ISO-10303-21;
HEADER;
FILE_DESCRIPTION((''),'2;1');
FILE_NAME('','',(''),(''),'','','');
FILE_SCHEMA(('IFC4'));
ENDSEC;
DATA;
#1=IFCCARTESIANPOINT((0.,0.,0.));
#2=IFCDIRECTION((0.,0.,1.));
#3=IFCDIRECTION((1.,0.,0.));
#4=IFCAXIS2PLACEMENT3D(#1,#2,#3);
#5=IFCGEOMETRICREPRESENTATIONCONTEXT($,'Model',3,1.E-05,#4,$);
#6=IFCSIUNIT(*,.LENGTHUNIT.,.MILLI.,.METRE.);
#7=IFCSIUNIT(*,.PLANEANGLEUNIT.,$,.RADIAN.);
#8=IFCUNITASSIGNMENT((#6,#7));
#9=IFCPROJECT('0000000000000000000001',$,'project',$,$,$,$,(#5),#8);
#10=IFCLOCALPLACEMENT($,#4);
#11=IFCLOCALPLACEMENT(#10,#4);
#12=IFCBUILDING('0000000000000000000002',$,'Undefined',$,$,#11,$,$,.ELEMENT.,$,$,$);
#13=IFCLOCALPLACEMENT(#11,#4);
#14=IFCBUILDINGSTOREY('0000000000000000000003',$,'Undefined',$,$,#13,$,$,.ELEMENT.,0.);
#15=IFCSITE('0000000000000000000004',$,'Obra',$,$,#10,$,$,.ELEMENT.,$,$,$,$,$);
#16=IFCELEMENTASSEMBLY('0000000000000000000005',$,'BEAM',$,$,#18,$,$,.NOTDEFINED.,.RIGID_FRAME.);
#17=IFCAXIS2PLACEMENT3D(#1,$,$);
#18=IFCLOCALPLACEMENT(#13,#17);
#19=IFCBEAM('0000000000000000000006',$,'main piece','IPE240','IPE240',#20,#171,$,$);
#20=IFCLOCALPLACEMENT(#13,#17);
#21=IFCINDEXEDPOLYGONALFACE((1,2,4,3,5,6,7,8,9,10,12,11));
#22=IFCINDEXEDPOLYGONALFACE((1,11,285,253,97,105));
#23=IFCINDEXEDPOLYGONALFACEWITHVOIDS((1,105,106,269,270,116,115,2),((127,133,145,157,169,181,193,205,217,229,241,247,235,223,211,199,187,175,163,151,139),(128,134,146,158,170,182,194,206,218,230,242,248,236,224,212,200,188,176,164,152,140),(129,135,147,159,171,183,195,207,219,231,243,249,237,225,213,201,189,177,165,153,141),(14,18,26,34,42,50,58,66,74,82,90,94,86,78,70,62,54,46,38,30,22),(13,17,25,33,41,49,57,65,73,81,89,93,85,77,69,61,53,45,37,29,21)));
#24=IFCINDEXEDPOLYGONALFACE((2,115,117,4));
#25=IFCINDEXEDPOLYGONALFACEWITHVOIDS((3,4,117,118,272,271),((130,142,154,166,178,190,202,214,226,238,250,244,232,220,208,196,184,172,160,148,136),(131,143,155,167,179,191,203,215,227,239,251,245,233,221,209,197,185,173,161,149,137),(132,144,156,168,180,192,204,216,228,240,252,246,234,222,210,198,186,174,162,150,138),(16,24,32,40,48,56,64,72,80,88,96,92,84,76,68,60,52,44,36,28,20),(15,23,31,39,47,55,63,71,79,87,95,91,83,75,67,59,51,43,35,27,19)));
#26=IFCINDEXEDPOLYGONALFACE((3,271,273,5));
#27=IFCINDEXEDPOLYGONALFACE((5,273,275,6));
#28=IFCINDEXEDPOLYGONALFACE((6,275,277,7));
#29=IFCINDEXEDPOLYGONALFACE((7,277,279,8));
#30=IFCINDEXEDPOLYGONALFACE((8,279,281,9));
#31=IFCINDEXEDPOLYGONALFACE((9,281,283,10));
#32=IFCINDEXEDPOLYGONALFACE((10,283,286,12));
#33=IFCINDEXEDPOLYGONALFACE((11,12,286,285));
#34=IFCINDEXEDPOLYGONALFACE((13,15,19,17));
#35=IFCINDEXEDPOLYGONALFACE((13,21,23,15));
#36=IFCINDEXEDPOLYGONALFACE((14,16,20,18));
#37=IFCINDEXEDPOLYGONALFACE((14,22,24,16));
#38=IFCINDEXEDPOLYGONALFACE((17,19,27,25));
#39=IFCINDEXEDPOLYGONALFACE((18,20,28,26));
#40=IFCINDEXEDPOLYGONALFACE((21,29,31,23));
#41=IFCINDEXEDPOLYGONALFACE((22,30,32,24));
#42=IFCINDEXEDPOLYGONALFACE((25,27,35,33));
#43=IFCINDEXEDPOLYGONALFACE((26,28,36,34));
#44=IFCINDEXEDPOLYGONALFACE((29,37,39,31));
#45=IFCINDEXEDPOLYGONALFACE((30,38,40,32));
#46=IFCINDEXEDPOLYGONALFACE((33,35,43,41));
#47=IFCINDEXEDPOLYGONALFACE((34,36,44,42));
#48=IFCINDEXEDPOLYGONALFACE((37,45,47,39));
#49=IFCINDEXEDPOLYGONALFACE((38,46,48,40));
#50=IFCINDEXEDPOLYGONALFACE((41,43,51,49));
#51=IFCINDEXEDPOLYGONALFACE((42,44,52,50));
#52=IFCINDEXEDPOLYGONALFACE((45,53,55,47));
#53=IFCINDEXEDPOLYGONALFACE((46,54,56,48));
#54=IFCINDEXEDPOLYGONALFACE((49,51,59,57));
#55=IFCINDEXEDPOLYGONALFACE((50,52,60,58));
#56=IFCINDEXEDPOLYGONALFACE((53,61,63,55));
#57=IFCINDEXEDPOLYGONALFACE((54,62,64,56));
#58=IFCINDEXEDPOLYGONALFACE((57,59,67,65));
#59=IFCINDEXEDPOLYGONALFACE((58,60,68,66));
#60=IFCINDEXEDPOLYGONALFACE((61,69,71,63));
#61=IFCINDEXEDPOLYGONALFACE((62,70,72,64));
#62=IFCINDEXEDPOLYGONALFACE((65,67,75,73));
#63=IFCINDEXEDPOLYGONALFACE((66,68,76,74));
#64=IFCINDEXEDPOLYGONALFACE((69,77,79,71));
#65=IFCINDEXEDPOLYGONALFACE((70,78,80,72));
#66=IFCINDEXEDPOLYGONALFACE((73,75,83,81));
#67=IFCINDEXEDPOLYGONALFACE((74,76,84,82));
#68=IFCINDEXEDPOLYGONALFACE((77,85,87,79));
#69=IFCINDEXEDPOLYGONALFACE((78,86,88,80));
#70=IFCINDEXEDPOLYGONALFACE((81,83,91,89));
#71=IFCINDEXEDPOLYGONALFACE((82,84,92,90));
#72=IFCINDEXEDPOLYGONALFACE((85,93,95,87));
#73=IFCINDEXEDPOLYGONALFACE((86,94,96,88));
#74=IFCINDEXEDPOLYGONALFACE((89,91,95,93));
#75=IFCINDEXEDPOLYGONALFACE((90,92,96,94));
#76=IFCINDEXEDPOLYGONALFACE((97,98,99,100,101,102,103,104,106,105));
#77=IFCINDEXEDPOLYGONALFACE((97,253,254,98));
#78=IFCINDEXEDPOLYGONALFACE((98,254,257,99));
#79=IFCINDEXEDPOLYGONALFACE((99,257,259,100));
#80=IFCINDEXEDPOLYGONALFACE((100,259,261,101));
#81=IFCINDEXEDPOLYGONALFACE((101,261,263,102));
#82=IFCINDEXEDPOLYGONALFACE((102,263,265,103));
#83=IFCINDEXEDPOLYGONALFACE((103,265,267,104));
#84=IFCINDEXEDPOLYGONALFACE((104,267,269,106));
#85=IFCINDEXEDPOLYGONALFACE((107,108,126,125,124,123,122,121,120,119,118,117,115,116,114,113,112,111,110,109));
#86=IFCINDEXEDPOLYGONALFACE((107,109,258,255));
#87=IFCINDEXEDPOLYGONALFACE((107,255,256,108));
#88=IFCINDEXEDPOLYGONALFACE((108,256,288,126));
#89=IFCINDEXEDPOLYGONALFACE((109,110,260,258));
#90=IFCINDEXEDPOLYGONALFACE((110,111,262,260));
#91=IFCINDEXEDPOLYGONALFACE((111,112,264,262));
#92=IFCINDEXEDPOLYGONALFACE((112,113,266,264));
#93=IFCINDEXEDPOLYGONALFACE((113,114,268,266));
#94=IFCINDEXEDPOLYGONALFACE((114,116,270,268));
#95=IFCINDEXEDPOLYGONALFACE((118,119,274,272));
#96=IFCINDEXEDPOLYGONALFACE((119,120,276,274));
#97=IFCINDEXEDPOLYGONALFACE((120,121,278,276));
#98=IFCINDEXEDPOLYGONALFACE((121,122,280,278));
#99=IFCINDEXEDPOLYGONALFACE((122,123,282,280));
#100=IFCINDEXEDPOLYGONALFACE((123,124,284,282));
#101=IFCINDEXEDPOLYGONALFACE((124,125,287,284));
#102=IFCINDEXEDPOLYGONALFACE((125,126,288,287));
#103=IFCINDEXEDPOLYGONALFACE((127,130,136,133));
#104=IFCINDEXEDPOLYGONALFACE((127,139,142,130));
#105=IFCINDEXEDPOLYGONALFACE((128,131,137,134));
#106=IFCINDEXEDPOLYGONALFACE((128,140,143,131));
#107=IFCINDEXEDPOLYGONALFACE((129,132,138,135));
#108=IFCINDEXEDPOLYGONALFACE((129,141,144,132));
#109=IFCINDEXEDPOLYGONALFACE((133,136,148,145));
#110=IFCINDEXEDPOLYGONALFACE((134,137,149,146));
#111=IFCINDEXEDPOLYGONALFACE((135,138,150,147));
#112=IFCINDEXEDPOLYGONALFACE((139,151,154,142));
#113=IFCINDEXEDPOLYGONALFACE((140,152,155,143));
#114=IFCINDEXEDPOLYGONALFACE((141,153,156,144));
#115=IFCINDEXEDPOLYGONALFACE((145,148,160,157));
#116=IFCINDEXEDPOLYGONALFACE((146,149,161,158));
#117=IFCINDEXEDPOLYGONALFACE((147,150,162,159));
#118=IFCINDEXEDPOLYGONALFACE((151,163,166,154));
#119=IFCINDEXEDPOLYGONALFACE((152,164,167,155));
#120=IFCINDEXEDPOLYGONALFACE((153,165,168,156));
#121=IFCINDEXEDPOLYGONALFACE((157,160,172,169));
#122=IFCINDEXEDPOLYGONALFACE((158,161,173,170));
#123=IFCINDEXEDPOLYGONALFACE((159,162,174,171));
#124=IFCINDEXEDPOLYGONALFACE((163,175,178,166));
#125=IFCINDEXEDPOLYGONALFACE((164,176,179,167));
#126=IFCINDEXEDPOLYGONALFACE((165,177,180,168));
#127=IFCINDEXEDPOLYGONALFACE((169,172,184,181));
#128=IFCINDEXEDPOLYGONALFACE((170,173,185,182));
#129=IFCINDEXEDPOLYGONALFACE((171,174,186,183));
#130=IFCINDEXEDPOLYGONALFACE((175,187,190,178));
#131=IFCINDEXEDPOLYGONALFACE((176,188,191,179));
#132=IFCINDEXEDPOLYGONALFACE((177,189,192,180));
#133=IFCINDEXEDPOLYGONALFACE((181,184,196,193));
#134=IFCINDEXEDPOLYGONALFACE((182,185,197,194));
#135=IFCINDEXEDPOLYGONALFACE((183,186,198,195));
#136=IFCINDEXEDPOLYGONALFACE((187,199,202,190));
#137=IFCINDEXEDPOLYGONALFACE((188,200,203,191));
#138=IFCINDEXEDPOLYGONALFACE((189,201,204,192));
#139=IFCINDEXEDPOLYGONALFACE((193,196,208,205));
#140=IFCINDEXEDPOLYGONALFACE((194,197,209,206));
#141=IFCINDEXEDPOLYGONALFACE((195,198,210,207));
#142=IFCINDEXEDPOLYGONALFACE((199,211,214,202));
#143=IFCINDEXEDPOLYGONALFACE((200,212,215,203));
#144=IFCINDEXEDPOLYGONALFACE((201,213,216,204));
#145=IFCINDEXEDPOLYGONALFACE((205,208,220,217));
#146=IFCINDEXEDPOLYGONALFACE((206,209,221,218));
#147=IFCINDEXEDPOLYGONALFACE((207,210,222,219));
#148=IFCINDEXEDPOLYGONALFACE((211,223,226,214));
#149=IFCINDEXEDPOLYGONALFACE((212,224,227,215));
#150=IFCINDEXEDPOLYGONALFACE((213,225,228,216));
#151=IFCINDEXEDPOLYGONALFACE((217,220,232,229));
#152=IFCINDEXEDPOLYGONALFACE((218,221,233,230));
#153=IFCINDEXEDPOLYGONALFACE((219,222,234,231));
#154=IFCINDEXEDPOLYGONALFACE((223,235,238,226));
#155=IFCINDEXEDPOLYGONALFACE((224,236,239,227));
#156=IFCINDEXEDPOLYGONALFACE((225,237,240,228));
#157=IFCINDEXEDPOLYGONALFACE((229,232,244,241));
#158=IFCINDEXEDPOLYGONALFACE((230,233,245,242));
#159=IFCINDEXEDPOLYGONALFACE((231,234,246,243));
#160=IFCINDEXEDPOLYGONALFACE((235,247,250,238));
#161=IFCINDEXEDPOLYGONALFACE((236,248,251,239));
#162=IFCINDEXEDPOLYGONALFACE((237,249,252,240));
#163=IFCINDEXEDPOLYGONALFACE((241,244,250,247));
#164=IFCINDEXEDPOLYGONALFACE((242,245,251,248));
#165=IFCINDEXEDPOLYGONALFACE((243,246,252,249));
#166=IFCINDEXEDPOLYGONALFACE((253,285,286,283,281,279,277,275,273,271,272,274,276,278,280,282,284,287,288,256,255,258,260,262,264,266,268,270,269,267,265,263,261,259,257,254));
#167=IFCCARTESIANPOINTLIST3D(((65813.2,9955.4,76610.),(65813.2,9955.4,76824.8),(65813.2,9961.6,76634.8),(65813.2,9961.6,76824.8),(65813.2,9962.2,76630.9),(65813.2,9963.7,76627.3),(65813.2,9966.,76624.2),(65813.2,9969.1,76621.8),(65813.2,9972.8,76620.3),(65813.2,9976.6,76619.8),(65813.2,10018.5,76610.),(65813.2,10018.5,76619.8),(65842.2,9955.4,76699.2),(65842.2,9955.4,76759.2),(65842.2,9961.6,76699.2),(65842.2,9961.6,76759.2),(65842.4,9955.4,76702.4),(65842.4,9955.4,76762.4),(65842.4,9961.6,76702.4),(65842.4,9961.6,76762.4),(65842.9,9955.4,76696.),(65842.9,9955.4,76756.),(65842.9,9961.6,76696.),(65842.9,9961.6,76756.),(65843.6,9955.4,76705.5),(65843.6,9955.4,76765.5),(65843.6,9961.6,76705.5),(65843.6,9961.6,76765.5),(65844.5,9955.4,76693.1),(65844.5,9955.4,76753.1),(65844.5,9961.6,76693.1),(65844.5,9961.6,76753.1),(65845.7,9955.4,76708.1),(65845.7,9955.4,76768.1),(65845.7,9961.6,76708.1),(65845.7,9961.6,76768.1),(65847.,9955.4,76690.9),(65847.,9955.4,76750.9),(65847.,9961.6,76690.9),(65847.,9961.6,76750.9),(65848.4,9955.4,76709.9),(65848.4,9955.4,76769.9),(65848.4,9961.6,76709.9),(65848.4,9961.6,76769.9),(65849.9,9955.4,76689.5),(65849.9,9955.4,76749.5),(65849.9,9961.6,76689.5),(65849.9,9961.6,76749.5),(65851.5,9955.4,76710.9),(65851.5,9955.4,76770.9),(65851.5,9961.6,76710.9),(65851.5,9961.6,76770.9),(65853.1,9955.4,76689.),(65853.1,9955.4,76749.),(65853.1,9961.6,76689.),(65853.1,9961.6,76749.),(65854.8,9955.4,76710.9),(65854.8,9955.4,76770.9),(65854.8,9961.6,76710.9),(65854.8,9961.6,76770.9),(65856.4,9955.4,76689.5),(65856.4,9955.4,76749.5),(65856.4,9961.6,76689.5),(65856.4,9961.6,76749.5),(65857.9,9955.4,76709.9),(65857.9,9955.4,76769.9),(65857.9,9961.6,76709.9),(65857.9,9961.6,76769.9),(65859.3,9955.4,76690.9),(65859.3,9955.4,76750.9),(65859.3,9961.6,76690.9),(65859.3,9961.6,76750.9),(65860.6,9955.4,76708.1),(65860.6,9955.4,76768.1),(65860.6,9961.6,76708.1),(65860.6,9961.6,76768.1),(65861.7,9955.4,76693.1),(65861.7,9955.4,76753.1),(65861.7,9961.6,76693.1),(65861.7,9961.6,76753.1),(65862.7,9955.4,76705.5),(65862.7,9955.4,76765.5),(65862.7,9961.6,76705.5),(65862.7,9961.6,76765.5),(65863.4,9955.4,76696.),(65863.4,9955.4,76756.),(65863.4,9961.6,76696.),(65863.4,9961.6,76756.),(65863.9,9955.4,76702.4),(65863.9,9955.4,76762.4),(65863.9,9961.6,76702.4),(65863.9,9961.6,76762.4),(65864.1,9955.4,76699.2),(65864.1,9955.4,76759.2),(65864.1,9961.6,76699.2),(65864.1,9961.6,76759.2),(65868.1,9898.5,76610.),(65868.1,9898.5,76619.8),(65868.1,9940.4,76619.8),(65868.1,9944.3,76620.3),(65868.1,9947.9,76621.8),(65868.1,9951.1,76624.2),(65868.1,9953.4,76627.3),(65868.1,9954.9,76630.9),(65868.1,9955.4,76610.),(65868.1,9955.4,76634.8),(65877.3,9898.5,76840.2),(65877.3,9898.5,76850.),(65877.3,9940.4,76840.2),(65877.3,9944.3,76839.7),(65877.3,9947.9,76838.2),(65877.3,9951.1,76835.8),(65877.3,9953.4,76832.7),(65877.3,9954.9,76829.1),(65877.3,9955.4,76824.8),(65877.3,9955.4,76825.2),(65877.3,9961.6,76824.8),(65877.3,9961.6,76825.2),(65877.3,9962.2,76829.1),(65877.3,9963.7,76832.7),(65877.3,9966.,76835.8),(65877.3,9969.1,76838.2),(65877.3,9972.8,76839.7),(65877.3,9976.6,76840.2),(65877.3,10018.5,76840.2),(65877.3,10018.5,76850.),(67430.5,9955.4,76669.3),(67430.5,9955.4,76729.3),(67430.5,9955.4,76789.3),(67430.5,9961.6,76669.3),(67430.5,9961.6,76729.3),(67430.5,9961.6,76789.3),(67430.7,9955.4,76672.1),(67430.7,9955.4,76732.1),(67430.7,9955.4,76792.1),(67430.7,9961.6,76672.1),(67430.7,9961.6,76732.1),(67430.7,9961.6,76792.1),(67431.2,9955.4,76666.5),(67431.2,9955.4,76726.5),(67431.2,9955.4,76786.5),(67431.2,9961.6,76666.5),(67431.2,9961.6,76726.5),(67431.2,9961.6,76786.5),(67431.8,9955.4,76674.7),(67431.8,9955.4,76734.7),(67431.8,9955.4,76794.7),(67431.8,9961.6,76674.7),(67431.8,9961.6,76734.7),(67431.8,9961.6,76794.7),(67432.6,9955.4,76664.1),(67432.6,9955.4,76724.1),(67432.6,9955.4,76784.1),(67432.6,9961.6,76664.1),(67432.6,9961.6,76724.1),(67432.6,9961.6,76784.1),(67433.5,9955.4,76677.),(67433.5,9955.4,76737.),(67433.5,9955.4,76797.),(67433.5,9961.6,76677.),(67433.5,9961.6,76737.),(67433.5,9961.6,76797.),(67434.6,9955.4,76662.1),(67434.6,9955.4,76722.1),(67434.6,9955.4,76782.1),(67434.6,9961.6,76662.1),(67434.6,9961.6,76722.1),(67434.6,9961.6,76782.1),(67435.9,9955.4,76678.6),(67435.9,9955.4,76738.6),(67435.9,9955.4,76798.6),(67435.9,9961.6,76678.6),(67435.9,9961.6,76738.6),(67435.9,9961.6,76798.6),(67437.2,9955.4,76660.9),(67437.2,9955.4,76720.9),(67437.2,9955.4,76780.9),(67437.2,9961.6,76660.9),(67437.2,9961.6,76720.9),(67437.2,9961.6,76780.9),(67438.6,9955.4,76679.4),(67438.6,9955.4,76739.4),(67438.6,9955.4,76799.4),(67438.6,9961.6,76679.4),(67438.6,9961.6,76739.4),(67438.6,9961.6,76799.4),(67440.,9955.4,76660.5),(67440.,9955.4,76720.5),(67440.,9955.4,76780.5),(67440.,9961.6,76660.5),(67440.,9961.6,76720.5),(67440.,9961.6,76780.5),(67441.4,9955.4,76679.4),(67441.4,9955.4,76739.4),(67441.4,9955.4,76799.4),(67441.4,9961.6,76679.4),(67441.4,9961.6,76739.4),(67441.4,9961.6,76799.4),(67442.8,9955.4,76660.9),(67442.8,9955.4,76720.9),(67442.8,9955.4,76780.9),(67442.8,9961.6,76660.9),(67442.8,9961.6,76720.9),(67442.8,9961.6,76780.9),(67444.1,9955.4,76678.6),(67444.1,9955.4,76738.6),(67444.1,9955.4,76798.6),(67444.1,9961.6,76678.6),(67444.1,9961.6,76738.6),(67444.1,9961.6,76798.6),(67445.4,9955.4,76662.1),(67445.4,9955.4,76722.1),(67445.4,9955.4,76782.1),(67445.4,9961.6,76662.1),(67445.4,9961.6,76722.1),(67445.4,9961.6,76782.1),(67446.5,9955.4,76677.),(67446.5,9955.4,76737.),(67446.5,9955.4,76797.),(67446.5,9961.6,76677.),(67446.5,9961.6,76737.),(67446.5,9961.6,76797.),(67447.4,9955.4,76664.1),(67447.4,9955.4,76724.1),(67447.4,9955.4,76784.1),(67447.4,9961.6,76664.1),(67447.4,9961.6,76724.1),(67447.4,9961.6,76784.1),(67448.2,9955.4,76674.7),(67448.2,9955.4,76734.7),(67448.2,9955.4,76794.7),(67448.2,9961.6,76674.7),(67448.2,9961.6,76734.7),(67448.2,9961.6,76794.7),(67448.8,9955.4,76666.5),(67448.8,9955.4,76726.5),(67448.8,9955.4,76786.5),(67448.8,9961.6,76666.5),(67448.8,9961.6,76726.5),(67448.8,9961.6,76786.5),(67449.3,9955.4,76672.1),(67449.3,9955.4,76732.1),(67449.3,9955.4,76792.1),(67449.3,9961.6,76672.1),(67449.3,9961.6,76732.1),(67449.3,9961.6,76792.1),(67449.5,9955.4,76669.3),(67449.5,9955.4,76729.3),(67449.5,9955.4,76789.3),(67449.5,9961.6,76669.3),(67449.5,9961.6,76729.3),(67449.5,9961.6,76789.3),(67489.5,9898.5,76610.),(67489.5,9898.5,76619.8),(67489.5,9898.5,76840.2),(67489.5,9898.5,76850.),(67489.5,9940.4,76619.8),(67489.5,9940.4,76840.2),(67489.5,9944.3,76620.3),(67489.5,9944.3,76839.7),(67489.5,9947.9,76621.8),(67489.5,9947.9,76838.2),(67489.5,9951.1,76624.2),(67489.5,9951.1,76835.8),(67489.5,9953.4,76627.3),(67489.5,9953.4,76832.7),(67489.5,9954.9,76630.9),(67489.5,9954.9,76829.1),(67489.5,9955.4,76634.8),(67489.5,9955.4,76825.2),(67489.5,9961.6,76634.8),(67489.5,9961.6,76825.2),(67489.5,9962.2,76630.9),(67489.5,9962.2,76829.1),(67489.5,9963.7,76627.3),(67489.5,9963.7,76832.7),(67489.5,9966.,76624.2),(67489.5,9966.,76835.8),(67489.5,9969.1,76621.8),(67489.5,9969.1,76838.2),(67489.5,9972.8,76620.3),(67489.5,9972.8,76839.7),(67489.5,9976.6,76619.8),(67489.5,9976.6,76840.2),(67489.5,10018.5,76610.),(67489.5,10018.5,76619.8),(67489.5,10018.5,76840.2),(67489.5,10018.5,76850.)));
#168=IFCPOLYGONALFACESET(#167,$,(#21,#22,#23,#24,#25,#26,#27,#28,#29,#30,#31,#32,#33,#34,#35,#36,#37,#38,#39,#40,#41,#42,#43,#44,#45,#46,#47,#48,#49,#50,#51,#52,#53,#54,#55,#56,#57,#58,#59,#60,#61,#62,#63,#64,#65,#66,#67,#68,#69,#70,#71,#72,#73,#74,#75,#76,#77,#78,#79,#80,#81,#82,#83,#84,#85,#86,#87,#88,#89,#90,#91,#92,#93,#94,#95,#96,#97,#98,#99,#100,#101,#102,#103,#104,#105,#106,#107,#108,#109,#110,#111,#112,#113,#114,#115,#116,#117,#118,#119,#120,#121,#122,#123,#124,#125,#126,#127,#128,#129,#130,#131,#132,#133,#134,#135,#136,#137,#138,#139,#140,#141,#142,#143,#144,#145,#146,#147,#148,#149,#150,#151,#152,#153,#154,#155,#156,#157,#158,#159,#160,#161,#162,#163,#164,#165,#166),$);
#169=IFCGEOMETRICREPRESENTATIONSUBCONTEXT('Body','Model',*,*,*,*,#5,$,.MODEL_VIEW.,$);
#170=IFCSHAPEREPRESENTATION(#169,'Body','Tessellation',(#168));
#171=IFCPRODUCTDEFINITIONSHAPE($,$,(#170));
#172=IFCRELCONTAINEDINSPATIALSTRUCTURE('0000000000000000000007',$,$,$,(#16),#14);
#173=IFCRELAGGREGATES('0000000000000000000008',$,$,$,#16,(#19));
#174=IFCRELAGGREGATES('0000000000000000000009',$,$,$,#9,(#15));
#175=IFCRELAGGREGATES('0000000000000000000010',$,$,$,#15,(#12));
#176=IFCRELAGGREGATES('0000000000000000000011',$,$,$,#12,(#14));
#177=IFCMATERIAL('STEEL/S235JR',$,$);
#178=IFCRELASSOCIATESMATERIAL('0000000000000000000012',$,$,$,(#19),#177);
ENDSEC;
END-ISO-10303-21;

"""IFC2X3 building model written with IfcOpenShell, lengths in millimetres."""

from ifc_helpers import new_model, si_unit, frame, origin_with_axes, origin_2d_with_axis, place, context, subcontext, project, spatial, rectangle, circle, i_section, extrude, clip, halfspace, source, transform, mapped, material, element, aggregate, save


model = new_model("IFC2X3")

# Units and contexts
model_context = context("Model", 3, precision=1e-05, world=origin_with_axes())
body_context = subcontext(model_context, "Body", "Model", "MODEL_VIEW")
ifc_project = project(units=[si_unit("LENGTHUNIT", "METRE", prefix="MILLI"), si_unit("PLANEANGLEUNIT", "RADIAN")], contexts=[model_context])

# Site, building, storey
site_placement = place(None, origin_with_axes())
site = spatial("IfcSite", under=ifc_project, at=site_placement, Name="Obra", CompositionType="ELEMENT")
building_placement = place(site_placement, origin_with_axes())
building = spatial("IfcBuilding", under=site, at=building_placement, Name="Undefined", CompositionType="ELEMENT")
storey_placement = place(building_placement, origin_with_axes())
storey = spatial("IfcBuildingStorey", under=building, at=storey_placement, Name="Undefined", CompositionType="ELEMENT", Elevation=0.0)

# Element assembly, beam, openings
ifc_material_1 = material(Name="STEEL/S235JR")
shared_shape_1 = source(origin_with_axes(), body_context, "Body", "SweptSolid", [
    extrude(circle(Radius=9.5, at=origin_2d_with_axis()), frame((0.0, -3.2, 0.0), z_axis=(0.0, 1.0, 0.0), x_axis=(1.0, 0.0, 0.0)), (0.0, 0.0, 1.0), 6.4),
])
shared_shape_2 = source(origin_with_axes(), body_context, "Body", "SweptSolid", [
    extrude(circle(Radius=11.0, at=origin_2d_with_axis()), frame((0.0, -3.2, 0.0), z_axis=(0.0, 1.0, 0.0), x_axis=(1.0, 0.0, 0.0)), (0.0, 0.0, 1.0), 6.4),
])
assembly_1_placement = place(storey_placement, origin_with_axes())
assembly_1 = element("IfcElementAssembly", 1, at=assembly_1_placement, inside=storey, Name="BEAM", AssemblyPlace="NOTDEFINED", PredefinedType="RIGID_FRAME")
beam_1_placement = place(assembly_1_placement, frame((65880.1, 9958.5, 76730.0), z_axis=(0.0, 0.0, 1.0), x_axis=(1.0, 0.0, 0.0)))
beam_1 = element("IfcBeam", 2, at=beam_1_placement, material=ifc_material_1, Name="main piece", Description="IPE240", ObjectType="IPE240", context=body_context, shape_type="Clipping", body=[
    clip(clip(extrude(i_section(OverallWidth=120.0, OverallDepth=240.0, WebThickness=6.2, FlangeThickness=9.8, FilletRadius=15.0, at=origin_2d_with_axis()), frame((1895.0, 0.0, 0.0), z_axis=(-1.0, 0.0, 0.0), x_axis=(0.0, -1.0, 0.0)), (0.0, 0.0, 1.0), 1961.9), halfspace(frame((1609.5, -60.0, -120.0), z_axis=(1.0, 0.000019, 0.0), x_axis=(0.0, 0.0, 1.0)), False)), halfspace(frame((-66.9, 0.0, -220.0), z_axis=(1.0, 0.0, 0.0), x_axis=(0.0, -1.0, 0.0)), True)),
])
opening_1_placement = place(assembly_1_placement, frame((65880.1, 9958.5, 76730.0), z_axis=(0.0, 0.0, 1.0), x_axis=(1.0, 0.0, 0.0)))
element("IfcOpeningElement", 3, at=opening_1_placement, cuts=beam_1, ObjectType="Recess", context=body_context, shape_type="SweptSolid", body=[
    extrude(rectangle(XDim=65.0, YDim=300.0, at=origin_2d_with_axis()), frame((-44.4, -153.1, 109.8), z_axis=(0.0, 0.0, -1.0), x_axis=(1.0, 0.0, 0.0)), (0.0, 0.0, 1.0), 249.6),
])
opening_2_placement = place(assembly_1_placement, frame((65880.1, 9958.5, 76730.0), z_axis=(0.0, 0.0, 1.0), x_axis=(1.0, 0.0, 0.0)))
element("IfcOpeningElement", 4, at=opening_2_placement, cuts=beam_1, ObjectType="Recess", context=body_context, shape_type="SweptSolid", body=[
    extrude(rectangle(XDim=26.2, YDim=76.2, at=origin_2d_with_axis()), frame((-40.8, -61.0, 107.9), z_axis=(0.0, 1.0, 0.0), x_axis=(0.0, 0.0, -1.0)), (0.0, 0.0, 1.0), 122.0),
])
opening_3_placement = place(assembly_1_placement, frame((65813.1, 9958.5, 76850.0), z_axis=(1.0, 0.0, 0.0), x_axis=(0.0, 0.0, -1.0)))
element("IfcOpeningElement", 5, at=opening_3_placement, cuts=beam_1, ObjectType="Opening", context=body_context, shape_type="MappedRepresentation", body=[
    mapped(shared_shape_2, transform((90.0, 0.0, 40.0))),
    mapped(shared_shape_2, transform((150.0, 0.0, 40.0))),
])
opening_4_placement = place(assembly_1_placement, frame((67490.0, 9958.5, 76850.0), z_axis=(-1.0, 0.0, 0.0), x_axis=(0.0, 0.0, -1.0)))
element("IfcOpeningElement", 6, at=opening_4_placement, cuts=beam_1, ObjectType="Opening", context=body_context, shape_type="MappedRepresentation", body=[
    mapped(shared_shape_1, transform((60.0, 0.0, 50.0))),
    mapped(shared_shape_1, transform((120.0, 0.0, 50.0))),
    mapped(shared_shape_1, transform((180.0, 0.0, 50.0))),
])

aggregate(assembly_1, [beam_1])

save(model, "model.ifc")
